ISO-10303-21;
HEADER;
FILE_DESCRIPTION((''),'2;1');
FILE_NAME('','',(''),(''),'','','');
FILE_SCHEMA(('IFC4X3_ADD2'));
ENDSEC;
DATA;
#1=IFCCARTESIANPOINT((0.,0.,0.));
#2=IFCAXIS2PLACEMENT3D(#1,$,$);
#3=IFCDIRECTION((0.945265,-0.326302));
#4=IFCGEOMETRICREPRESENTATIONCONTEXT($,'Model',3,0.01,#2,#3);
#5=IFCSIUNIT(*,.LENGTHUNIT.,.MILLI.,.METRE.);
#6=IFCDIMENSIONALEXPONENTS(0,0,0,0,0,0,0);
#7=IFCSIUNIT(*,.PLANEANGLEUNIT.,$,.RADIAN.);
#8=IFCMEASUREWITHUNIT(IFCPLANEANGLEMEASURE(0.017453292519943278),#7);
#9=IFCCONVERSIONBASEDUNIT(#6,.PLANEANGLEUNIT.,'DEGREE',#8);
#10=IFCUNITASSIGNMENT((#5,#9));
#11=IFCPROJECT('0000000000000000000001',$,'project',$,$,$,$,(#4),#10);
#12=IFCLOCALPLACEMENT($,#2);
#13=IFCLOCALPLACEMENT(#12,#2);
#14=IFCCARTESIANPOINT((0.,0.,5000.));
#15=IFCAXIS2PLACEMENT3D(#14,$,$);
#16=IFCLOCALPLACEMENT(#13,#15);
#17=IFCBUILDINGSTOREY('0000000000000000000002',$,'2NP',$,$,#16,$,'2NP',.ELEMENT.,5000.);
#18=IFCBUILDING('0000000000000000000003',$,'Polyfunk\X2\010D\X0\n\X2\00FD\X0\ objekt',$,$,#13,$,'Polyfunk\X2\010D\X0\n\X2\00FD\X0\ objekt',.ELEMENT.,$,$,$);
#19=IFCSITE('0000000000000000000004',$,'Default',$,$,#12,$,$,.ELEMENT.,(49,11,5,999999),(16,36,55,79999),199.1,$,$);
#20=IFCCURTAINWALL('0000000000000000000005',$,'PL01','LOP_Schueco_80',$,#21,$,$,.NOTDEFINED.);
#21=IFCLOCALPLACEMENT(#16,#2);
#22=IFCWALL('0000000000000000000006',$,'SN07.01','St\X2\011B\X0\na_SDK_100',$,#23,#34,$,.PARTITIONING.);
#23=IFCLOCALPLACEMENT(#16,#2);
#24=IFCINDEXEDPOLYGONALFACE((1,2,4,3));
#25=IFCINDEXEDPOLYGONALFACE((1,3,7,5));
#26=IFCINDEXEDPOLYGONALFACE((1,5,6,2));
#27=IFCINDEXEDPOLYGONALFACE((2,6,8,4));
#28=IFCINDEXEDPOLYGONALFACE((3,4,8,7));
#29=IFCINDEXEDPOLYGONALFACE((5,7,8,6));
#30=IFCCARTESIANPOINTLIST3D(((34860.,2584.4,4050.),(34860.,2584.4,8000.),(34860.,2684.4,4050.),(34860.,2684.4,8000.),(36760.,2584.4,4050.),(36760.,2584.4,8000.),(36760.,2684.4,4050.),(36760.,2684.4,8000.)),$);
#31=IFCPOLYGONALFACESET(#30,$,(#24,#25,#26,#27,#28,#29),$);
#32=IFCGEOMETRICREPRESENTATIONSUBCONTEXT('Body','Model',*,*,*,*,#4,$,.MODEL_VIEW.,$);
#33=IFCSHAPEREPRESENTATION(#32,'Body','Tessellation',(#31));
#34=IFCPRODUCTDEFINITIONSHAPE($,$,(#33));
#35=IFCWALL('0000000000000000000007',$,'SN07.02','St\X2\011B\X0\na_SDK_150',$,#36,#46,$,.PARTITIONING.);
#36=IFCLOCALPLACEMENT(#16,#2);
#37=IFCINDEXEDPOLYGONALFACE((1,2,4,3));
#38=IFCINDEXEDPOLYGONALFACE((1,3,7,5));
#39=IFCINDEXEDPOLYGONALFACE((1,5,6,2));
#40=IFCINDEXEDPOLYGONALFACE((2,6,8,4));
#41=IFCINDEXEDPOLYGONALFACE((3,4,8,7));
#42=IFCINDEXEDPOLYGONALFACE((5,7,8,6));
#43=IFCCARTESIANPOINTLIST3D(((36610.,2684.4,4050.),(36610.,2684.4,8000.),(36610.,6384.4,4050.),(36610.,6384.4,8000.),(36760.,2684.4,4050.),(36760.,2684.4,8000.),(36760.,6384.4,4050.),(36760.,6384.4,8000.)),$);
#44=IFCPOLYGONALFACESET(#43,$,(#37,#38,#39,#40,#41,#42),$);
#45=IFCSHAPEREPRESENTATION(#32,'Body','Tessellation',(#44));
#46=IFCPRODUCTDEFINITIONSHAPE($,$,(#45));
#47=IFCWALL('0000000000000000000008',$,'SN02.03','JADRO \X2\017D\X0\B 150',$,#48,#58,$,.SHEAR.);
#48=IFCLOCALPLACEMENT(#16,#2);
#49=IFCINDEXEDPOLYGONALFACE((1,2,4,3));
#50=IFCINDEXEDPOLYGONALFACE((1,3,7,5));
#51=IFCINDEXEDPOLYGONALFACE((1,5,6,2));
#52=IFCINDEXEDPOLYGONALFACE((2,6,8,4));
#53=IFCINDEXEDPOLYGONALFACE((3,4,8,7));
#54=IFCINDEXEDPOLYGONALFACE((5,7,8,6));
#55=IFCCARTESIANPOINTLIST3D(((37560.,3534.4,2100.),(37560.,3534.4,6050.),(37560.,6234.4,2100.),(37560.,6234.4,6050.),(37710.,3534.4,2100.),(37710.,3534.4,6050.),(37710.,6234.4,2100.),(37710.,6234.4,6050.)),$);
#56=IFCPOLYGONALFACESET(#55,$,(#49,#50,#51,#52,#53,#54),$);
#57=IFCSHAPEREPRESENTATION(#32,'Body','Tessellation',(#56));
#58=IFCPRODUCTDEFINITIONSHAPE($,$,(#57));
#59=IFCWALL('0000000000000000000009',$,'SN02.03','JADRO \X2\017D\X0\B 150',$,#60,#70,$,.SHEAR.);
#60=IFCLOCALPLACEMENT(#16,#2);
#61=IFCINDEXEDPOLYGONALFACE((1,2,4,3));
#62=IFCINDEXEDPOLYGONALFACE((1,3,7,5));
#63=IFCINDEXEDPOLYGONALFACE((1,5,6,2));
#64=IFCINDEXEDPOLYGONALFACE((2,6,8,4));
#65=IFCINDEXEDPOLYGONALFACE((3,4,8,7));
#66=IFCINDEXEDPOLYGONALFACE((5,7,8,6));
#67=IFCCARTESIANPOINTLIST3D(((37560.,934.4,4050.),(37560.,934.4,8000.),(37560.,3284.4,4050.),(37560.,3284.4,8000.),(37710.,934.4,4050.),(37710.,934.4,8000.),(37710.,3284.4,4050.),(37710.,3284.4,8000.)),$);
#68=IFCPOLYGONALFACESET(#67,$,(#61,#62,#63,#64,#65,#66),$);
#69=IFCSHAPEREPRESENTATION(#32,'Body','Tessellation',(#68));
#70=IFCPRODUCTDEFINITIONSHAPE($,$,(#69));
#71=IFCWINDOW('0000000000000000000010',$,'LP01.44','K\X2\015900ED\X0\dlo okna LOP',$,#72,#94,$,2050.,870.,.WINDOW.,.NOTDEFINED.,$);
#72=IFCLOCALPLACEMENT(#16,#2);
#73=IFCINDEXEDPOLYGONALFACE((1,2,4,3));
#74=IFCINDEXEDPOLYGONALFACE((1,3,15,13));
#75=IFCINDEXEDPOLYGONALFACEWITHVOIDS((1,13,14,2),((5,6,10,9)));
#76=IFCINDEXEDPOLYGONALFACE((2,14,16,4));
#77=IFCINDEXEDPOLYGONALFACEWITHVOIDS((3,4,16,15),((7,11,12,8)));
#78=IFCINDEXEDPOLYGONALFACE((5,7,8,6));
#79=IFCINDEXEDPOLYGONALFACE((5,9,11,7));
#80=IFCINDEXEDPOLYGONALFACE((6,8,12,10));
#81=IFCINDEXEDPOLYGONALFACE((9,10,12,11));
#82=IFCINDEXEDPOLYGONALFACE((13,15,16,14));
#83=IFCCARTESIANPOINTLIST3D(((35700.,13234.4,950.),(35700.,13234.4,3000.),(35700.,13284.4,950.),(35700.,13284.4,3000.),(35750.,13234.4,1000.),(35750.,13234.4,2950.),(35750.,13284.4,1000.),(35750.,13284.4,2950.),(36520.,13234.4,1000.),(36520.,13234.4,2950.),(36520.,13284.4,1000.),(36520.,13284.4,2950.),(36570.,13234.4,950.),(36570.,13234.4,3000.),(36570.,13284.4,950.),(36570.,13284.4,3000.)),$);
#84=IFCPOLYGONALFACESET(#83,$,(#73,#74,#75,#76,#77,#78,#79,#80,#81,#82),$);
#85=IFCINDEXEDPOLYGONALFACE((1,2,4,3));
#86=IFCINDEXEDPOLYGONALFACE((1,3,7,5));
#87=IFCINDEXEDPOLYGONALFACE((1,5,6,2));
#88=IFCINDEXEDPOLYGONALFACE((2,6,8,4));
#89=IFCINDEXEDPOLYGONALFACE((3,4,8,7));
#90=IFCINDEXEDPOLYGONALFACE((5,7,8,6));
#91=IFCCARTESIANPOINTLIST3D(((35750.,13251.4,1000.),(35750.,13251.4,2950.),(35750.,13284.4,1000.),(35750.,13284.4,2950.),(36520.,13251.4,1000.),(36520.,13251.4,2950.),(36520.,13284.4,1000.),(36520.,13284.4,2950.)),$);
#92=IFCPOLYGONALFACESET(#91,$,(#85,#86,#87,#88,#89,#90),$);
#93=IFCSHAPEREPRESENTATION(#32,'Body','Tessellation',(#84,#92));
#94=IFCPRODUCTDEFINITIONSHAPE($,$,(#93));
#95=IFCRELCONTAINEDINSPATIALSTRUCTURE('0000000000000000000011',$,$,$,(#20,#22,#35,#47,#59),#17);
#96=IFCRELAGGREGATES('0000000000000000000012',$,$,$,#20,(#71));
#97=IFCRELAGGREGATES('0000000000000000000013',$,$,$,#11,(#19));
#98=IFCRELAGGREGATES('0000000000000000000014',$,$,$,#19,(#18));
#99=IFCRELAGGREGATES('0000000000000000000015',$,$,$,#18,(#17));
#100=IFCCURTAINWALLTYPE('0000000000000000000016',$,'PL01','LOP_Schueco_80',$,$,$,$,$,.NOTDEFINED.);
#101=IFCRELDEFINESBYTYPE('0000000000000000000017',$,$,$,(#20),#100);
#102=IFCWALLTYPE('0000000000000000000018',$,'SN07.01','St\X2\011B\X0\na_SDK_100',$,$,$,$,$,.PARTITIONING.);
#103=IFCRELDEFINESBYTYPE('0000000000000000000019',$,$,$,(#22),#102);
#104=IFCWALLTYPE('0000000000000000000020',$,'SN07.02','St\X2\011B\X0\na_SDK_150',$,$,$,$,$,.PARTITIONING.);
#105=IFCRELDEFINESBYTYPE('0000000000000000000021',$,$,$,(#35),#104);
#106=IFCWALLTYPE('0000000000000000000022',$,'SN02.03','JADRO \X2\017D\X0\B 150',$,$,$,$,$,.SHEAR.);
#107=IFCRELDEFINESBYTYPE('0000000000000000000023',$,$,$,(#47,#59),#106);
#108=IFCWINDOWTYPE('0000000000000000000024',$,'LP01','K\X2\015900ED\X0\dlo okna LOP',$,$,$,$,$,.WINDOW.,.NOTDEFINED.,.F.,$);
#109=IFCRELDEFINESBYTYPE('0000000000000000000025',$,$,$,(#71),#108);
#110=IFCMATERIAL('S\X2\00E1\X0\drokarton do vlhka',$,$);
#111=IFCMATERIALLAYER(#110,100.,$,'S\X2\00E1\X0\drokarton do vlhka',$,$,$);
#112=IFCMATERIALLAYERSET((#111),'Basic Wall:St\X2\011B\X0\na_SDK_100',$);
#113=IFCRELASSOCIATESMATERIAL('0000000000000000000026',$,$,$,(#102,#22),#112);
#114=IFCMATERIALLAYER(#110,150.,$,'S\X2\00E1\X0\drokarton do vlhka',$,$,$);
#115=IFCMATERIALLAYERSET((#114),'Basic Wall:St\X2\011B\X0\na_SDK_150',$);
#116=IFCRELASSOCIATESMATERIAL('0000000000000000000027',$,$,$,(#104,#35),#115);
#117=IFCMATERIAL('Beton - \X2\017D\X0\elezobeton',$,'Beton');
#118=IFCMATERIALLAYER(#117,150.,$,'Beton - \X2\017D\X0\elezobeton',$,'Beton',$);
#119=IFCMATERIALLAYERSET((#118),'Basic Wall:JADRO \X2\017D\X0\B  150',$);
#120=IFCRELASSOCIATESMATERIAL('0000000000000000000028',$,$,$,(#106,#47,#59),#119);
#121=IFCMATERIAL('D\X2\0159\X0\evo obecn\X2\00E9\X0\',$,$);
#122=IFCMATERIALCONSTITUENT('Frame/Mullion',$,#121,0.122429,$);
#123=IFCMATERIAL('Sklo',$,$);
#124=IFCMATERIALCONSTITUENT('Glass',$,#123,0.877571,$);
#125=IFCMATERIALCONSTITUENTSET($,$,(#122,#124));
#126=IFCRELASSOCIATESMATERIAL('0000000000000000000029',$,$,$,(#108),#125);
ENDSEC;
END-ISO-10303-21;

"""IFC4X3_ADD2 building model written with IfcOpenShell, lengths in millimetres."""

from ifc_helpers import new_model, entity, si_unit, converted_unit, direction, frame, frame_2d, origin, origin_2d_with_axis, place, context, subcontext, project, spatial, polyline, rectangle, outline, extrude, clip, bounded_halfspace, source, transform, mapped, material, layer, layer_set, constituent, constituent_set, type_object, type_shapes, element, aggregate, save


model = new_model("IFC4X3_ADD2")

# Units and contexts
model_context = context("Model", 3, precision=0.01, world=origin(), true_north=direction((0.945265, -0.326302)))
body_context = subcontext(model_context, "Body", "Model", "MODEL_VIEW")
ifc_project = project(units=[si_unit("LENGTHUNIT", "METRE", prefix="MILLI"), converted_unit("PLANEANGLEUNIT", "DEGREE", entity("IfcPlaneAngleMeasure", 0.017453292519943278), si_unit("PLANEANGLEUNIT", "RADIAN"), dimensions=[0, 0, 0, 0, 0, 0, 0])], contexts=[model_context])

# Site, building, storey
site_placement = place(None, origin())
site = spatial("IfcSite", under=ifc_project, at=site_placement, Name="Default", CompositionType="ELEMENT", RefLatitude=(49, 11, 5, 999999), RefLongitude=(16, 36, 55, 79999), RefElevation=199.1)
building_placement = place(site_placement, origin())
building = spatial("IfcBuilding", under=site, at=building_placement, Name="Polyfunkčný objekt", LongName="Polyfunkčný objekt", CompositionType="ELEMENT")
storey_placement = place(building_placement, frame((0.0, 0.0, 5000.0)))
storey = spatial("IfcBuildingStorey", under=building, at=storey_placement, Name="2NP", LongName="2NP", CompositionType="ELEMENT", Elevation=5000.0)

# Curtain wall
curtain_wall_type = type_object("IfcCurtainWallType", Name="PL01", Description="LOP_Schueco_80", PredefinedType="NOTDEFINED")
curtain_wall_placement = place(storey_placement, frame((0.0, 0.0, -5000.0)))
curtain_wall = element("IfcCurtainWall", 1, at=curtain_wall_placement, inside=storey, type_object=curtain_wall_type, Name="PL01", Description="LOP_Schueco_80", PredefinedType="NOTDEFINED")
ifc_material_1 = material(Name="Sklo")

# Walls
ifc_material_2 = material(Name="Sádrokarton do vlhka")
ifc_layer_1 = layer(ifc_material_2, 100.0, Name="Sádrokarton do vlhka")
ifc_layer_set_1 = layer_set([ifc_layer_1], Name="Basic Wall:Stěna_SDK_100")
wall_type_1 = type_object("IfcWallType", Name="SN07.01", Description="Stěna_SDK_100", PredefinedType="PARTITIONING", material=ifc_layer_set_1)
wall_1_placement = place(storey_placement, frame((34860.0, 2634.4, 4050.0)))
element("IfcWall", 2, at=wall_1_placement, inside=storey, type_object=wall_type_1, material=ifc_layer_set_1, Name="SN07.01", Description="Stěna_SDK_100", PredefinedType="PARTITIONING", context=body_context, shape_type="Clipping", body=[
    clip(clip(extrude(rectangle(XDim=1900.0, YDim=100.0, at=frame_2d((950.0, 0.0), x_axis=(-1.0, 0.0))), origin(), (0.0, 0.0, 1.0), 3950.0), bounded_halfspace(frame((1900.0, -50.0, 0.0), z_axis=(0.0, 0.0, 1.0), x_axis=(-1.0, 0.0, 0.0)), True, frame((1900.0, -50.0, 0.0)), polyline([(0.0, 0.0), (0.0, 100.0), (-150.0, 100.0), (-1900.0, 100.0), (-1900.0, 0.0), (-1800.0, 0.0), (0.0, 0.0)]))), bounded_halfspace(frame((0.0, -50.0, 3950.0), z_axis=(0.0, 0.0, -1.0), x_axis=(1.0, 0.0, 0.0)), True, frame((0.0, -50.0, 3950.0)), polyline([(0.0, 0.0), (100.0, 0.0), (1900.0, 0.0), (1900.0, 100.0), (1750.0, 100.0), (0.0, 100.0), (0.0, 0.0)]))),
])
ifc_layer_2 = layer(ifc_material_2, 150.0, Name="Sádrokarton do vlhka")
ifc_layer_set_2 = layer_set([ifc_layer_2], Name="Basic Wall:Stěna_SDK_150")
wall_type_2 = type_object("IfcWallType", Name="SN07.02", Description="Stěna_SDK_150", PredefinedType="PARTITIONING", material=ifc_layer_set_2)
wall_2_placement = place(storey_placement, frame((36685.0, 6384.4, 4050.0), z_axis=(0.0, 0.0, 1.0), x_axis=(0.0, -1.0, 0.0)))
element("IfcWall", 3, at=wall_2_placement, inside=storey, type_object=wall_type_2, material=ifc_layer_set_2, Name="SN07.02", Description="Stěna_SDK_150", PredefinedType="PARTITIONING", context=body_context, shape_type="SweptSolid", body=[
    extrude(rectangle(XDim=3700.0, YDim=150.0, at=frame_2d((1850.0, 0.0), x_axis=(-1.0, 0.0))), origin(), (0.0, 0.0, 1.0), 3950.0),
])

# Walls
ifc_material_3 = material(Name="Beton - Železobeton", Category="Beton")
ifc_layer_3 = layer(ifc_material_3, 150.0, Name="Beton - Železobeton", Category="Beton")
ifc_layer_set_3 = layer_set([ifc_layer_3], Name="Basic Wall:JADRO ŽB  150")
wall_type_3 = type_object("IfcWallType", Name="SN02.03", Description="JADRO ŽB 150", PredefinedType="SHEAR", material=ifc_layer_set_3)
wall_3_placement = place(storey_placement, frame((37635.0, 6234.4, 2100.0), z_axis=(0.0, 0.0, 1.0), x_axis=(0.0, -1.0, 0.0)))
element("IfcWall", 4, at=wall_3_placement, inside=storey, type_object=wall_type_3, material=ifc_layer_set_3, Name="SN02.03", Description="JADRO ŽB 150", PredefinedType="SHEAR", context=body_context, shape_type="SweptSolid", body=[
    extrude(rectangle(XDim=2700.0, YDim=150.0, at=frame_2d((1350.0, 0.0), x_axis=(-1.0, 0.0))), origin(), (0.0, 0.0, 1.0), 3950.0),
])
wall_4_placement = place(storey_placement, frame((37635.0, 3284.4, 4050.0), z_axis=(0.0, 0.0, 1.0), x_axis=(0.0, -1.0, 0.0)))
element("IfcWall", 5, at=wall_4_placement, inside=storey, type_object=wall_type_3, material=ifc_layer_set_3, Name="SN02.03", Description="JADRO ŽB 150", PredefinedType="SHEAR", context=body_context, shape_type="SweptSolid", body=[
    extrude(rectangle(XDim=2350.0, YDim=150.0, at=frame_2d((1175.0, 0.0), x_axis=(-1.0, 0.0))), origin(), (0.0, 0.0, 1.0), 3950.0),
])

# Window
ifc_material_4 = material(Name="Dřevo obecné")
ifc_constituent_1 = constituent(ifc_material_4, Name="Frame/Mullion", fraction=0.122429)
ifc_constituent_2 = constituent(ifc_material_1, Name="Glass", fraction=0.877571)
ifc_constituent_set = constituent_set(constituents=[ifc_constituent_1, ifc_constituent_2])
window_type = type_object("IfcWindowType", Name="LP01", Description="Křídlo okna LOP", ParameterTakesPrecedence=False, PartitioningType="NOTDEFINED", PredefinedType="WINDOW", material=ifc_constituent_set)
shared_shape_1 = source(origin(), body_context, "Body", "SweptSolid", [
    extrude(outline(polyline([(-1025.0, -435.0), (1025.0, -435.0), (1025.0, 435.0), (-1025.0, 435.0), (-1025.0, -435.0)]), holes=[polyline([(-975.0, -385.0), (-975.0, 385.0), (975.0, 385.0), (975.0, -385.0), (-975.0, -385.0)])]), frame((0.0, 0.0, 1025.0), z_axis=(0.0, 1.0, 0.0), x_axis=(0.0, 0.0, -1.0)), (0.0, 0.0, 1.0), 50.0),
    extrude(rectangle(XDim=33.0, YDim=770.0, at=origin_2d_with_axis()), frame((0.0, 33.5, 50.0), z_axis=(0.0, 0.0, 1.0), x_axis=(0.0, -1.0, 0.0)), (0.0, 0.0, 1.0), 1950.0),
])
type_shapes(window_type, [shared_shape_1])
window_placement = place(curtain_wall_placement, frame((36135.0, 13234.4, 5950.0)))
window = element("IfcWindow", 6, at=window_placement, type_object=window_type, Name="LP01.44", Description="Křídlo okna LOP", OverallHeight=2050.0, OverallWidth=870.0, PartitioningType="NOTDEFINED", PredefinedType="WINDOW", context=body_context, shape_type="MappedRepresentation", body=[
    mapped(shared_shape_1, transform((0.0, 0.0, 0.0), scale=1.0)),
])
aggregate(curtain_wall, [window])

save(model, "model.ifc")
